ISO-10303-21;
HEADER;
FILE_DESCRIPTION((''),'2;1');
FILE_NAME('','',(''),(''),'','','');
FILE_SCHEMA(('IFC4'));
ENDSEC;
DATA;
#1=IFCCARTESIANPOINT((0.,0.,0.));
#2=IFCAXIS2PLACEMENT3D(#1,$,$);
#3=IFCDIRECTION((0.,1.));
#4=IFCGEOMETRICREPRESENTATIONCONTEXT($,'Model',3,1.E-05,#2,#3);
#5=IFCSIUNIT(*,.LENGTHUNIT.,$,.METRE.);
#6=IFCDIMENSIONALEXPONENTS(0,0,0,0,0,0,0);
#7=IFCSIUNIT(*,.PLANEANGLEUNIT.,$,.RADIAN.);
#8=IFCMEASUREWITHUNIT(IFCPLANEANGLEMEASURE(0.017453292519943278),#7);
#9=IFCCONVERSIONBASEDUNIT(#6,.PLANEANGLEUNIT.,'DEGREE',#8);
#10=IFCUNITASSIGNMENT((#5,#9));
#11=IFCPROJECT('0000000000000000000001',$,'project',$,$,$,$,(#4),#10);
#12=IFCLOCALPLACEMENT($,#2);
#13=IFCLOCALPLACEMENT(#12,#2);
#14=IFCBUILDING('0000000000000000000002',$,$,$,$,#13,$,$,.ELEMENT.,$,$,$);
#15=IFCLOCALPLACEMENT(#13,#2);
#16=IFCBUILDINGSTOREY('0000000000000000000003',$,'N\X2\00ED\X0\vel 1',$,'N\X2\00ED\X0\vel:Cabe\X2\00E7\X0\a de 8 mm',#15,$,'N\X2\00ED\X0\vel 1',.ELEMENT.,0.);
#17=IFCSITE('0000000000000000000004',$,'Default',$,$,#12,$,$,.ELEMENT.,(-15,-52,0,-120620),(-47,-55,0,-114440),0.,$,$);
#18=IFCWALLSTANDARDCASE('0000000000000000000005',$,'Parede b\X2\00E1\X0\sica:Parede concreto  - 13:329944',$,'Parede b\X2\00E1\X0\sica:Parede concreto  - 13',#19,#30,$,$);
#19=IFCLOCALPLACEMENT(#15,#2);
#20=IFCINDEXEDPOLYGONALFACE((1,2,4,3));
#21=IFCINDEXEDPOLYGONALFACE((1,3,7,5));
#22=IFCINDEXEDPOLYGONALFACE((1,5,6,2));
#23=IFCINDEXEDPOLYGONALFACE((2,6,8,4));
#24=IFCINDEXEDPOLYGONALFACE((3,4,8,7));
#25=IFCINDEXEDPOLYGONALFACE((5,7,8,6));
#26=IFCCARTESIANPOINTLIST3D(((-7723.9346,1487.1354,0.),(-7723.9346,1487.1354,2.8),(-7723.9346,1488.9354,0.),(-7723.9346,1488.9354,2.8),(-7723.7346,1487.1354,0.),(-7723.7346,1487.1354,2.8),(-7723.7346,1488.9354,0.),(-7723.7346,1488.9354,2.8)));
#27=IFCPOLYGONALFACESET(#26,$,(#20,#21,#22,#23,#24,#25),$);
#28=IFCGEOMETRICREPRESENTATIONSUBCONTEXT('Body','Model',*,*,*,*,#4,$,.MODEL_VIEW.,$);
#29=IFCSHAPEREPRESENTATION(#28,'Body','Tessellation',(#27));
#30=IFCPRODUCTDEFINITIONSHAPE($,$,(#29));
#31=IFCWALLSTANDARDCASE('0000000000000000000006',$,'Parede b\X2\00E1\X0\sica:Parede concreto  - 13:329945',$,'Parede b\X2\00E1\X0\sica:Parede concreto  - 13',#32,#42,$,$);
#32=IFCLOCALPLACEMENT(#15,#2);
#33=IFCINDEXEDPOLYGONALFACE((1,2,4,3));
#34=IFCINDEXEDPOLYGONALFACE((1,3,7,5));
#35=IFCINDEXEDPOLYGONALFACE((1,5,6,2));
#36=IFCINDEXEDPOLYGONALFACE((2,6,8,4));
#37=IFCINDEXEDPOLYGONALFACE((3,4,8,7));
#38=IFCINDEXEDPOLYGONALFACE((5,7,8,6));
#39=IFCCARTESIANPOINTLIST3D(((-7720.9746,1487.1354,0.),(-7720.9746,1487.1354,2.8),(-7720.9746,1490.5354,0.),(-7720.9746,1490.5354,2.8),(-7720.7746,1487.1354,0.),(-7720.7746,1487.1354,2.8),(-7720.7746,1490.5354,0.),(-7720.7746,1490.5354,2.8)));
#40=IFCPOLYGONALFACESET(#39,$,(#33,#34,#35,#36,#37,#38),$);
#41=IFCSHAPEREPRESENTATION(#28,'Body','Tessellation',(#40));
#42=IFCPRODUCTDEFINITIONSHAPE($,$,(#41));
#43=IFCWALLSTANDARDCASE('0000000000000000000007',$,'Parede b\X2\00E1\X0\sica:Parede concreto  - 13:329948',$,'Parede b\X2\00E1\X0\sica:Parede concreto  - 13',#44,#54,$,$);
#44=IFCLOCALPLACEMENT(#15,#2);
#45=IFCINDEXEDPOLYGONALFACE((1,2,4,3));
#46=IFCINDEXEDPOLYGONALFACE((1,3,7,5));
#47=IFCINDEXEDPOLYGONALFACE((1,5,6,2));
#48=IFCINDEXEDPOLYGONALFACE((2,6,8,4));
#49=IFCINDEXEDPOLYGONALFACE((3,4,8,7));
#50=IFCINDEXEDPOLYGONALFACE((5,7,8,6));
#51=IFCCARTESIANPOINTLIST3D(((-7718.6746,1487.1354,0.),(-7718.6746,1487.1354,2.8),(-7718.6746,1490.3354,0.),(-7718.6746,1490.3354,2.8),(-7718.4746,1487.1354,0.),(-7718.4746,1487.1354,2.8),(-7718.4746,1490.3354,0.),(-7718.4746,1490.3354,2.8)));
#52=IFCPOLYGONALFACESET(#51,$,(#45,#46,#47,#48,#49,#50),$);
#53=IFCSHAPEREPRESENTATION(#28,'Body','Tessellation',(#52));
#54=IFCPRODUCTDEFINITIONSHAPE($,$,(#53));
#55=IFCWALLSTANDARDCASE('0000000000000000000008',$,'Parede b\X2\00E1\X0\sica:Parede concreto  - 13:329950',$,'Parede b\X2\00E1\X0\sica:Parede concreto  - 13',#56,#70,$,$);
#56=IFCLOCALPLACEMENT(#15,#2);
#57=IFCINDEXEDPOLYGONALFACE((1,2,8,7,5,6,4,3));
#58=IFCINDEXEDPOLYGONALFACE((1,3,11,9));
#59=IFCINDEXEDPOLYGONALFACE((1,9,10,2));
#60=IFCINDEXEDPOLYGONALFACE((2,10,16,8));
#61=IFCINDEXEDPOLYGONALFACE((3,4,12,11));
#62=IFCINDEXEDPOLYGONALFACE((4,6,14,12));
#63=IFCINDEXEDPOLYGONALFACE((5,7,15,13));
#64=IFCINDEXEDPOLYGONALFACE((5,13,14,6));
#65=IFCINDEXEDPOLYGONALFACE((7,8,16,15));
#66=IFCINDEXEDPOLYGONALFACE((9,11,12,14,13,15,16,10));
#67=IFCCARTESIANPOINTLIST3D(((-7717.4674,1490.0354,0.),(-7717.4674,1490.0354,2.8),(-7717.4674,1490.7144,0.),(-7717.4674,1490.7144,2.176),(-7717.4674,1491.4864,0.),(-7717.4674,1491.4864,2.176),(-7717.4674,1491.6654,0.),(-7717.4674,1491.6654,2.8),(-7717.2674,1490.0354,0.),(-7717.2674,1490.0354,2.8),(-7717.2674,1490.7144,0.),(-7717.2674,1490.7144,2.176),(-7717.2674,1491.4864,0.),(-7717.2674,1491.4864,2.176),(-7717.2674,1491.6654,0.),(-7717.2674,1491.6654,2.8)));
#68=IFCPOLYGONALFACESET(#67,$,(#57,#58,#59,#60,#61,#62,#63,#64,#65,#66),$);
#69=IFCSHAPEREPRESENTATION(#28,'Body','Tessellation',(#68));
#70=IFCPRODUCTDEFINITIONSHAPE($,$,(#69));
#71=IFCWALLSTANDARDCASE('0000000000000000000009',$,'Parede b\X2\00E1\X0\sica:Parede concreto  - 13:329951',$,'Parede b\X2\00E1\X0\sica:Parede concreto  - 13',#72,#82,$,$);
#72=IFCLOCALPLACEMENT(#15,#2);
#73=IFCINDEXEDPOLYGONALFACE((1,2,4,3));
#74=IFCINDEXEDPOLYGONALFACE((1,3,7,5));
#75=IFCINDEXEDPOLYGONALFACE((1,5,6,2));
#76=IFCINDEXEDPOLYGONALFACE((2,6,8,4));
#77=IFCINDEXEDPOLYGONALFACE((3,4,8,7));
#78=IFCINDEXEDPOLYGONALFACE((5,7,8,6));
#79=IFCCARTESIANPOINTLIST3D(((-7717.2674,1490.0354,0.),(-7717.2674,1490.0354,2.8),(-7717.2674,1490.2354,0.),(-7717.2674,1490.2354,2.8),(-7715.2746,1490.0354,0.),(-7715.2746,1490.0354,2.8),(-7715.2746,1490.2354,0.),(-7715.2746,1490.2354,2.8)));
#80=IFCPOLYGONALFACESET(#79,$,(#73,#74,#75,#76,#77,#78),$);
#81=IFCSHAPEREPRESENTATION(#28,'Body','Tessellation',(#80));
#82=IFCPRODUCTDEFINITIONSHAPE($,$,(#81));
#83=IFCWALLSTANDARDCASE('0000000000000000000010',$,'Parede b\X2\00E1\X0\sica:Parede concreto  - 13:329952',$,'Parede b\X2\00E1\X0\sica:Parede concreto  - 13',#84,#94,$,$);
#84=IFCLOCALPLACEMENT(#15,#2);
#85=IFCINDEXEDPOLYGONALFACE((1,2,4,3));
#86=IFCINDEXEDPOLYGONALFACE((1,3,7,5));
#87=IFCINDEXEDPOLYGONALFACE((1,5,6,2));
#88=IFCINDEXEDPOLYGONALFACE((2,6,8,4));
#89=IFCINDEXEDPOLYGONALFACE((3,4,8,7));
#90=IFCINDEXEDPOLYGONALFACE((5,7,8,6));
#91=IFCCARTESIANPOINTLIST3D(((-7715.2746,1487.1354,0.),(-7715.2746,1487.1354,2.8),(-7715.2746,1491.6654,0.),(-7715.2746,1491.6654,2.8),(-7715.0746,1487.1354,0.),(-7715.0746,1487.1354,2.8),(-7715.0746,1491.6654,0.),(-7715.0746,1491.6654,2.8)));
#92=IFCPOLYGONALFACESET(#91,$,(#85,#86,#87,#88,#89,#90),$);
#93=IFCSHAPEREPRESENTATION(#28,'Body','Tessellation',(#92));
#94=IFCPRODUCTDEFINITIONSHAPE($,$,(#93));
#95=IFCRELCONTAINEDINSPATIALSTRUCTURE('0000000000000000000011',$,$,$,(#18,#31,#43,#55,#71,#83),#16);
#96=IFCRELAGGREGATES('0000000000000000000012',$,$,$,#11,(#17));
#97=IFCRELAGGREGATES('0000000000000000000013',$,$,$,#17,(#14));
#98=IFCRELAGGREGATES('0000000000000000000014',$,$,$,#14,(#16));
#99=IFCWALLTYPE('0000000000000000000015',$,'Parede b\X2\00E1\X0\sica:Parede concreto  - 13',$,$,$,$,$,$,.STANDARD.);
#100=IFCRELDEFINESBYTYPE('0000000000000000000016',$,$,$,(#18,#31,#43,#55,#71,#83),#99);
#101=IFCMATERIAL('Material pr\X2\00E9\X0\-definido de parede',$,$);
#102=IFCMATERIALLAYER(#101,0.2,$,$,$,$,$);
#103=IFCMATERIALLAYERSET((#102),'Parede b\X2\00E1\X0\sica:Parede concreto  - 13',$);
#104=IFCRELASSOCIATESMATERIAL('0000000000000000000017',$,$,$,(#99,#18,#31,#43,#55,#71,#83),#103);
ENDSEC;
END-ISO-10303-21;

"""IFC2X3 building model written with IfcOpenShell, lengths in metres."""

from ifc_helpers import new_model, entity, si_unit, converted_unit, direction, frame, frame_2d, origin, place, context, subcontext, project, spatial, rectangle, extrude, material, layer, layer_set, layer_usage, type_object, element, save


model = new_model("IFC2X3")

# Units and contexts
model_context = context("Model", 3, precision=1e-05, world=origin(), true_north=direction((0.0, 1.0)))
body_context = subcontext(model_context, "Body", "Model", "MODEL_VIEW")
ifc_project = project(units=[si_unit("LENGTHUNIT", "METRE"), converted_unit("PLANEANGLEUNIT", "DEGREE", entity("IfcPlaneAngleMeasure", 0.017453292519943278), si_unit("PLANEANGLEUNIT", "RADIAN"), dimensions=[0, 0, 0, 0, 0, 0, 0])], contexts=[model_context])

# Site, building, storey
site_placement = place(None, origin())
site = spatial("IfcSite", under=ifc_project, at=site_placement, Name="Default", CompositionType="ELEMENT", RefLatitude=(-15, -52, 0, -120620), RefLongitude=(-47, -55, 0, -114440), RefElevation=0.0)
building_placement = place(site_placement, origin())
building = spatial("IfcBuilding", under=site, at=building_placement, CompositionType="ELEMENT")
storey_placement = place(building_placement, origin())
storey = spatial("IfcBuildingStorey", under=building, at=storey_placement, Name="Nível 1", ObjectType="Nível:Cabeça de 8 mm", LongName="Nível 1", CompositionType="ELEMENT", Elevation=0.0)

# Shared definitions
ifc_material_1 = material(Name="Material pré-definido de parede")
ifc_layer_1 = layer(ifc_material_1, 0.2)
ifc_layer_set_1 = layer_set([ifc_layer_1], Name="Parede básica:Parede concreto  - 13")
wall_type = type_object("IfcWallType", Name="Parede básica:Parede concreto  - 13", PredefinedType="STANDARD", material=ifc_layer_set_1)

# Walls
ifc_layer_usage_1 = layer_usage(ifc_layer_set_1, "AXIS2", "POSITIVE", -0.1)
wall_1_placement = place(storey_placement, frame((-7723.8346, 1487.1354, 0.0), z_axis=(0.0, 0.0, 1.0), x_axis=(0.0, 1.0, 0.0)))
element("IfcWallStandardCase", 1, at=wall_1_placement, inside=storey, type_object=wall_type, material=ifc_layer_usage_1, Name="Parede básica:Parede concreto  - 13:329944", ObjectType="Parede básica:Parede concreto  - 13", context=body_context, shape_type="SweptSolid", body=[
    extrude(rectangle(XDim=1.8, YDim=0.2, at=frame_2d((0.9, 0.0), x_axis=(-1.0, 0.0))), origin(), (0.0, 0.0, 1.0), 2.8),
])
ifc_layer_usage_2 = layer_usage(ifc_layer_set_1, "AXIS2", "POSITIVE", -0.1)
wall_2_placement = place(storey_placement, frame((-7720.8746, 1487.1354, 0.0), z_axis=(0.0, 0.0, 1.0), x_axis=(0.0, 1.0, 0.0)))
element("IfcWallStandardCase", 2, at=wall_2_placement, inside=storey, type_object=wall_type, material=ifc_layer_usage_2, Name="Parede básica:Parede concreto  - 13:329945", ObjectType="Parede básica:Parede concreto  - 13", context=body_context, shape_type="SweptSolid", body=[
    extrude(rectangle(XDim=3.4, YDim=0.2, at=frame_2d((1.7, 0.0), x_axis=(-1.0, 0.0))), origin(), (0.0, 0.0, 1.0), 2.8),
])
ifc_layer_usage_3 = layer_usage(ifc_layer_set_1, "AXIS2", "POSITIVE", -0.1)
wall_3_placement = place(storey_placement, frame((-7718.5746, 1487.1354, 0.0), z_axis=(0.0, 0.0, 1.0), x_axis=(0.0, 1.0, 0.0)))
element("IfcWallStandardCase", 3, at=wall_3_placement, inside=storey, type_object=wall_type, material=ifc_layer_usage_3, Name="Parede básica:Parede concreto  - 13:329948", ObjectType="Parede básica:Parede concreto  - 13", context=body_context, shape_type="SweptSolid", body=[
    extrude(rectangle(XDim=3.2, YDim=0.2, at=frame_2d((1.6, 0.0), x_axis=(-1.0, 0.0))), origin(), (0.0, 0.0, 1.0), 2.8),
])

# Wall, opening
ifc_layer_usage_4 = layer_usage(ifc_layer_set_1, "AXIS2", "POSITIVE", -0.1)
wall_4_placement = place(storey_placement, frame((-7717.3674, 1491.6654, 0.0), z_axis=(0.0, 0.0, 1.0), x_axis=(0.0, -1.0, 0.0)))
wall_4 = element("IfcWallStandardCase", 4, at=wall_4_placement, inside=storey, type_object=wall_type, material=ifc_layer_usage_4, Name="Parede básica:Parede concreto  - 13:329950", ObjectType="Parede básica:Parede concreto  - 13", context=body_context, shape_type="SweptSolid", body=[
    extrude(rectangle(XDim=1.63, YDim=0.2, at=frame_2d((0.815, 0.0), x_axis=(-1.0, 0.0))), origin(), (0.0, 0.0, 1.0), 2.8),
])
opening_1_placement = place(wall_4_placement, origin())
element("IfcOpeningElement", 5, at=opening_1_placement, cuts=wall_4, ObjectType="Opening", context=body_context, shape_type="SweptSolid", body=[
    extrude(rectangle(XDim=2.176, YDim=0.772, at=frame_2d((0.0, 0.0), x_axis=(0.0, 1.0))), frame((0.565, 0.1, 1.088), z_axis=(0.0, -1.0, 0.0), x_axis=(1.0, 0.0, 0.0)), (0.0, 0.0, 1.0), 0.2),
])

# Walls
ifc_layer_usage_5 = layer_usage(ifc_layer_set_1, "AXIS2", "POSITIVE", -0.1)
wall_5_placement = place(storey_placement, frame((-7717.2674, 1490.1354, 0.0)))
element("IfcWallStandardCase", 6, at=wall_5_placement, inside=storey, type_object=wall_type, material=ifc_layer_usage_5, Name="Parede básica:Parede concreto  - 13:329951", ObjectType="Parede básica:Parede concreto  - 13", context=body_context, shape_type="SweptSolid", body=[
    extrude(rectangle(XDim=1.9928, YDim=0.2, at=frame_2d((0.9964, 0.0), x_axis=(-1.0, 0.0))), origin(), (0.0, 0.0, 1.0), 2.8),
])
ifc_layer_usage_6 = layer_usage(ifc_layer_set_1, "AXIS2", "POSITIVE", -0.1)
wall_6_placement = place(storey_placement, frame((-7715.1746, 1487.1354, 0.0), z_axis=(0.0, 0.0, 1.0), x_axis=(0.0, 1.0, 0.0)))
element("IfcWallStandardCase", 7, at=wall_6_placement, inside=storey, type_object=wall_type, material=ifc_layer_usage_6, Name="Parede básica:Parede concreto  - 13:329952", ObjectType="Parede básica:Parede concreto  - 13", context=body_context, shape_type="SweptSolid", body=[
    extrude(rectangle(XDim=4.53, YDim=0.2, at=frame_2d((2.265, 0.0), x_axis=(-1.0, 0.0))), origin(), (0.0, 0.0, 1.0), 2.8),
])

save(model, "model.ifc")
